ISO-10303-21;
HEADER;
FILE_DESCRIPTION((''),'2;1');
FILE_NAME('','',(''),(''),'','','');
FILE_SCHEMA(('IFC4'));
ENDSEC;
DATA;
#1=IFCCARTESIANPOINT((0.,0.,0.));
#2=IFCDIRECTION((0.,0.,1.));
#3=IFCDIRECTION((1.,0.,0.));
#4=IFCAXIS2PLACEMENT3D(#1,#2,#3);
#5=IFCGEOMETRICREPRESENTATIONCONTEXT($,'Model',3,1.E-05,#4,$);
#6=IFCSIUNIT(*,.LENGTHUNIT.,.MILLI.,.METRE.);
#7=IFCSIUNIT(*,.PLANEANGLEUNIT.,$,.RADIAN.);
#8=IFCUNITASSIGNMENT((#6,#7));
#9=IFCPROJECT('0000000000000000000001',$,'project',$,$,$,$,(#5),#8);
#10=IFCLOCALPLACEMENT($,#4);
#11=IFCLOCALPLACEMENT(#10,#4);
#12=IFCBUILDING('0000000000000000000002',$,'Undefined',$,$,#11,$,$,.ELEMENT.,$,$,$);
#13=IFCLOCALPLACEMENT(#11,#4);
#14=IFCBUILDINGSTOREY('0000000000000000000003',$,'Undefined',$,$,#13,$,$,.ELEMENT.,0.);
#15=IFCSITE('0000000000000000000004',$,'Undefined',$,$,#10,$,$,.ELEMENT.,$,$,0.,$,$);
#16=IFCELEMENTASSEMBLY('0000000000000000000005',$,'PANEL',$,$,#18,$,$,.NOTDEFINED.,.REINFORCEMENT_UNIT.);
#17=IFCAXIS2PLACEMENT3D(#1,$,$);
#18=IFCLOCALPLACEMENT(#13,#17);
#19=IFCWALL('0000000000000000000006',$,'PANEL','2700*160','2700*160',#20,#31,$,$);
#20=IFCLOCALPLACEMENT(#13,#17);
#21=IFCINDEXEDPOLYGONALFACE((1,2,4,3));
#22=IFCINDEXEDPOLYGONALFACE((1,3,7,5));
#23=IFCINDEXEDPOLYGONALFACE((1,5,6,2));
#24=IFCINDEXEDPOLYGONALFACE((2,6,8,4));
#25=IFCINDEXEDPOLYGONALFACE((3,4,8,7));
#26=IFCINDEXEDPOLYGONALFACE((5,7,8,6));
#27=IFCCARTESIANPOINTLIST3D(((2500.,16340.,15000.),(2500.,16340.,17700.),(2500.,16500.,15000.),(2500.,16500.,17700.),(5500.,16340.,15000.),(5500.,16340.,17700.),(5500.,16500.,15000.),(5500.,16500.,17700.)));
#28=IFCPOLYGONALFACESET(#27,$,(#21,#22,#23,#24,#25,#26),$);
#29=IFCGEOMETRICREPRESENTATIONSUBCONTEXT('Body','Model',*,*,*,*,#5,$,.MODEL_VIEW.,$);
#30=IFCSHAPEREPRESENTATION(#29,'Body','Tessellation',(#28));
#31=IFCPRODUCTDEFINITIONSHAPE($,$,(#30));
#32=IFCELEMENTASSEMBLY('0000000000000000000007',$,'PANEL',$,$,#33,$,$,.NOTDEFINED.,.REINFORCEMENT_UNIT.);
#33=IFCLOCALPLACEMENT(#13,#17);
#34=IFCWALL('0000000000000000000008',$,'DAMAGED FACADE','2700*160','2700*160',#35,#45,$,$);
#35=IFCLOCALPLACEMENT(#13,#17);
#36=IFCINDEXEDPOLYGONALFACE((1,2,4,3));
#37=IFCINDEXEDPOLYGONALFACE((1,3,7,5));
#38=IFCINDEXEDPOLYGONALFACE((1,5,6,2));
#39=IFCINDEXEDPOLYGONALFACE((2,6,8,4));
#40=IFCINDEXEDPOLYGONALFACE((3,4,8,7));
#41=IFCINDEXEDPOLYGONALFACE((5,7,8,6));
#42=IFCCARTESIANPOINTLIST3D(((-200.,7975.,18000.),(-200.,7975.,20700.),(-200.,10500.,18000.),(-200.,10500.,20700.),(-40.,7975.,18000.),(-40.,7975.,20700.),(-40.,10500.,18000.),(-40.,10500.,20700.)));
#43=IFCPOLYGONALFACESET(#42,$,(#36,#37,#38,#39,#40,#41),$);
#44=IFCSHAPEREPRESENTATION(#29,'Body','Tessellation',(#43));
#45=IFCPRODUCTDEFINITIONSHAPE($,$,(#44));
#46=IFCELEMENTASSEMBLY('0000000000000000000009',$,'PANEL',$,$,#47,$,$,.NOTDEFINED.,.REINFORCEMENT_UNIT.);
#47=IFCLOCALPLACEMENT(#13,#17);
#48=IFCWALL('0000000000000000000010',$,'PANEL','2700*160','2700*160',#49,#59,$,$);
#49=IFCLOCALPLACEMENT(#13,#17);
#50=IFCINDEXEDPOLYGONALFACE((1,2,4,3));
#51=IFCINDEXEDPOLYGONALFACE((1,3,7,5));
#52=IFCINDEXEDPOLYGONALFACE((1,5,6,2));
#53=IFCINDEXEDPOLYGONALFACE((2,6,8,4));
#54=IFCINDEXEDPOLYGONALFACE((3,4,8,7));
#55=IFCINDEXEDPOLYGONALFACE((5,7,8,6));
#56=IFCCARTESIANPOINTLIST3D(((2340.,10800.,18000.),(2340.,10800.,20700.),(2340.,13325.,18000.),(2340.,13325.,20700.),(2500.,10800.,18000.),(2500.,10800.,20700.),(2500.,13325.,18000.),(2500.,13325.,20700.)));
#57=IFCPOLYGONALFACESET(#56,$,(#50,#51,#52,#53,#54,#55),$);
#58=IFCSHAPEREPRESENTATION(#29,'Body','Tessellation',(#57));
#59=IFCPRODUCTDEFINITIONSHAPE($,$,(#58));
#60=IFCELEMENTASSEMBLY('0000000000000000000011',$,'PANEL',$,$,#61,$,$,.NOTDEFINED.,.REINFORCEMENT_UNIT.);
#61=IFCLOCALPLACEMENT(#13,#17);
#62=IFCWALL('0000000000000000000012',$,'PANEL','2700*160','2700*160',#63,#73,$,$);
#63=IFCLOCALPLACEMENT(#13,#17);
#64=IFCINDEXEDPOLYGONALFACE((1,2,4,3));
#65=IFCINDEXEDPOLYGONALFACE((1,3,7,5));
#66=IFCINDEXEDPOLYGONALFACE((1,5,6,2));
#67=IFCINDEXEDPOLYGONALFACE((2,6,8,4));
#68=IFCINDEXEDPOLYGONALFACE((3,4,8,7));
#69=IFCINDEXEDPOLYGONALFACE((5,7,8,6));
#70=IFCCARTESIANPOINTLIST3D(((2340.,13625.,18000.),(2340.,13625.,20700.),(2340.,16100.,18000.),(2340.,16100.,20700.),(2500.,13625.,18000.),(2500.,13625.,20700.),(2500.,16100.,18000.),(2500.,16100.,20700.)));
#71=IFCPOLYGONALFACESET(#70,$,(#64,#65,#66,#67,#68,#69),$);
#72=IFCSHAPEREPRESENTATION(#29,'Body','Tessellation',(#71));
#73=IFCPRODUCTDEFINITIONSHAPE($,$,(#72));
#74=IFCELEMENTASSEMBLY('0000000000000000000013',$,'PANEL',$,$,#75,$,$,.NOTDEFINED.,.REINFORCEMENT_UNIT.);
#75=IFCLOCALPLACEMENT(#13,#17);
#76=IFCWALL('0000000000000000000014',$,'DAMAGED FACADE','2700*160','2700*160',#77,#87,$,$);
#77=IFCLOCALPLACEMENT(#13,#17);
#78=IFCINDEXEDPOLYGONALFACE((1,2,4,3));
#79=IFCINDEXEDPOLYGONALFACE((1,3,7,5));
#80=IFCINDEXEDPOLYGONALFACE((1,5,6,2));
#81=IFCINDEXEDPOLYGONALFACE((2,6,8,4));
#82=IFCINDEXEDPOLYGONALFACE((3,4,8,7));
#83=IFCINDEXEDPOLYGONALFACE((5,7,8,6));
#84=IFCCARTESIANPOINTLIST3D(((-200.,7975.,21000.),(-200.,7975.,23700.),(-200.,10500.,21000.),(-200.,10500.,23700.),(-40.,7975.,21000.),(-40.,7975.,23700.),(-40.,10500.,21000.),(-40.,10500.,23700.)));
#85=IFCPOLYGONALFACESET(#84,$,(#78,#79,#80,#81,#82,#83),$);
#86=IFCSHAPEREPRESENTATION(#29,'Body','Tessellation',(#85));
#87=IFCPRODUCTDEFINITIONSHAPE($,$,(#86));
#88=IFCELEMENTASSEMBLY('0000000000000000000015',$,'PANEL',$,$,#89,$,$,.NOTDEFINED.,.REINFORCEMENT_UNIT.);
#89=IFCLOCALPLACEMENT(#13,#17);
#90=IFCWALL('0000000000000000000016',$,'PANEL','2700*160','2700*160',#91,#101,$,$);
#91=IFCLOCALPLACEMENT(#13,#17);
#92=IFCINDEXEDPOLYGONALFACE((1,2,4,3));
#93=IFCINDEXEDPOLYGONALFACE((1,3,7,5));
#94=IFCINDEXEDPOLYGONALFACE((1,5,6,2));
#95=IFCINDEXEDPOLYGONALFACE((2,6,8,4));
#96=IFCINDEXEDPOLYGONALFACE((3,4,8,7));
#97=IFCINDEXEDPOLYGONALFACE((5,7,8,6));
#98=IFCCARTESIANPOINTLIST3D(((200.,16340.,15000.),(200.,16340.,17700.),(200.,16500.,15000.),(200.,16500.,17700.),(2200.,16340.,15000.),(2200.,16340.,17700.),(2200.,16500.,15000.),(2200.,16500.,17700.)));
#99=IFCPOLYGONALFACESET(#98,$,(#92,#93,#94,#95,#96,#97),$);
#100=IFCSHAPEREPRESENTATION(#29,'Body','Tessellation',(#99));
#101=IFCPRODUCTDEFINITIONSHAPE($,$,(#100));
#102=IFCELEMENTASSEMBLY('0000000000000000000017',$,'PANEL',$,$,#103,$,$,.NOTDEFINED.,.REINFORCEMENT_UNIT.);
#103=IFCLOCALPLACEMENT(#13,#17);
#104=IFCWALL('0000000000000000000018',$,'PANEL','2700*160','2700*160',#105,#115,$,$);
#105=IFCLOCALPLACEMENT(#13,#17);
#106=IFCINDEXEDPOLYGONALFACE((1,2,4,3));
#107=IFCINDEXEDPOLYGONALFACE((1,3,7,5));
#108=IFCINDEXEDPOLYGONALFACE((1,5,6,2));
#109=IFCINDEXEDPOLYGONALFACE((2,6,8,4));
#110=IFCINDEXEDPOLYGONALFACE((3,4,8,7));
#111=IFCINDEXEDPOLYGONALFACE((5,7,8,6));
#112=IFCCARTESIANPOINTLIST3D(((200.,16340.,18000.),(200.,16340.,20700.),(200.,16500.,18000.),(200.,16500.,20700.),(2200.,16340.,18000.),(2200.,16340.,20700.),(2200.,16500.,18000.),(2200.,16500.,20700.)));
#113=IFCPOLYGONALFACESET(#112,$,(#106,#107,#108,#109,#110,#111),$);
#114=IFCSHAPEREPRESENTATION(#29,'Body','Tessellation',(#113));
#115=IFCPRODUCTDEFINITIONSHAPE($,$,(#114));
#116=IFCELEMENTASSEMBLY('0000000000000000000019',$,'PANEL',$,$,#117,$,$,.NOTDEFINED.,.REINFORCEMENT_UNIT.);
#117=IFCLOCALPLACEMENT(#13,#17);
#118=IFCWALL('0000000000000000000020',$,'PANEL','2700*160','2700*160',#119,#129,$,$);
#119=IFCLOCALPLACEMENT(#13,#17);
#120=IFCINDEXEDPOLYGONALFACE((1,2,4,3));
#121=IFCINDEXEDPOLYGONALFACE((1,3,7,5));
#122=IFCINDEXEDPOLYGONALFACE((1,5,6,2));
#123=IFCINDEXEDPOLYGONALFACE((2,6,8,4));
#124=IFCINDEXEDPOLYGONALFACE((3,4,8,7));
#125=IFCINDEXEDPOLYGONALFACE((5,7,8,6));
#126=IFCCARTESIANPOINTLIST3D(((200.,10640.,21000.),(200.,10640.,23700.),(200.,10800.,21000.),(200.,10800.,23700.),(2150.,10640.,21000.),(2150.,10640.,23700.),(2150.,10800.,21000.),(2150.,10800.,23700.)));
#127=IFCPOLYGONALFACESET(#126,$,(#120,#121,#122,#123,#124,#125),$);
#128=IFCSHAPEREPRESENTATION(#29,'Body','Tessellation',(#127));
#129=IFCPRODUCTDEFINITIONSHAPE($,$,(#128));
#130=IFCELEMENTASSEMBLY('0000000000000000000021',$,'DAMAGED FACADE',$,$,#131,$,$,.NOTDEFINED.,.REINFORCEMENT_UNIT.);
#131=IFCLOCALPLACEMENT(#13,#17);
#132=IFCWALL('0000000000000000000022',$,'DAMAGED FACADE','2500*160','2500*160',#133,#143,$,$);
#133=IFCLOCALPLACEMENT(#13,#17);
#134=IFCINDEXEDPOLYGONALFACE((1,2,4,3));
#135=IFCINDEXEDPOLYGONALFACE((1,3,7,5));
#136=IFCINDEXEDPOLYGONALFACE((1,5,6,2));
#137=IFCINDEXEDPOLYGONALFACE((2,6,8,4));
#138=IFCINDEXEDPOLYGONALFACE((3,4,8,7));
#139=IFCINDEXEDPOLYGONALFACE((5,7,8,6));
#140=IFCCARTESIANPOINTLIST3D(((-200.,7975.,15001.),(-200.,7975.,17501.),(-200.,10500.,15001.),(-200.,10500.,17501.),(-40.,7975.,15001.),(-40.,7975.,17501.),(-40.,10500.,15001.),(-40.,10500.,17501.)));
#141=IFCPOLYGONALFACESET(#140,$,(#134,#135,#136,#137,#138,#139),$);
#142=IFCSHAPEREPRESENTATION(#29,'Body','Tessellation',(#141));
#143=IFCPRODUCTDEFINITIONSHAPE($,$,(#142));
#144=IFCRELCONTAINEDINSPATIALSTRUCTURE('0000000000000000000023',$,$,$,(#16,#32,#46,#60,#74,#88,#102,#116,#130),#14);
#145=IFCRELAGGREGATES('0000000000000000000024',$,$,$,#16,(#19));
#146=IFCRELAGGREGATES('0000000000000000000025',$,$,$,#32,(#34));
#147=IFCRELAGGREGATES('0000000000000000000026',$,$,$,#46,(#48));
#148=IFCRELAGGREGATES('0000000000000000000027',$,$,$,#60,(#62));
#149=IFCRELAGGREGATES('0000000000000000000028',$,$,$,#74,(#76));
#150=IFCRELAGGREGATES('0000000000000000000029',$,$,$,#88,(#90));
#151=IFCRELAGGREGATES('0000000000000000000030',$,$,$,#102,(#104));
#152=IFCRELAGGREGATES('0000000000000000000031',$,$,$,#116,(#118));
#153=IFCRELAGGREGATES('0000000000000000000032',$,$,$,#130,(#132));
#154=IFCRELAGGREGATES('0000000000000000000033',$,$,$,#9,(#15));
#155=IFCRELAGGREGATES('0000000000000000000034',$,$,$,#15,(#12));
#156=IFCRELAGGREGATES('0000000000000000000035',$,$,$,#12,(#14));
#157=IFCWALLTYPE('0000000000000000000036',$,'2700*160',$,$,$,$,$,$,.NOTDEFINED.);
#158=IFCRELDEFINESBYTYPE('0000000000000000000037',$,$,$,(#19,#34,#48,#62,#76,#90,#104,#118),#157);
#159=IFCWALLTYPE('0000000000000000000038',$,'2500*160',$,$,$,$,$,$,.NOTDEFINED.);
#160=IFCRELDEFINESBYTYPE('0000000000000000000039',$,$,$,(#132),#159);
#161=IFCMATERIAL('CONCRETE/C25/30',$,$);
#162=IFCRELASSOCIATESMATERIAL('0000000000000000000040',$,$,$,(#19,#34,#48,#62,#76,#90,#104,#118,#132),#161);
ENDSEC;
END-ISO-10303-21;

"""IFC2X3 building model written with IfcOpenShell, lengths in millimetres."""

from ifc_helpers import new_model, si_unit, frame, frame_2d, origin_with_axes, place, context, subcontext, project, spatial, rectangle, extrude, material, type_object, element, aggregate, save


model = new_model("IFC2X3")

# Units and contexts
model_context = context("Model", 3, precision=1e-05, world=origin_with_axes())
body_context = subcontext(model_context, "Body", "Model", "MODEL_VIEW")
ifc_project = project(units=[si_unit("LENGTHUNIT", "METRE", prefix="MILLI"), si_unit("PLANEANGLEUNIT", "RADIAN")], contexts=[model_context])

# Site, building, storey
site_placement = place(None, origin_with_axes())
site = spatial("IfcSite", under=ifc_project, at=site_placement, Name="Undefined", CompositionType="ELEMENT", RefElevation=0.0)
building_placement = place(site_placement, origin_with_axes())
building = spatial("IfcBuilding", under=site, at=building_placement, Name="Undefined", CompositionType="ELEMENT")
storey_placement = place(building_placement, origin_with_axes())
storey = spatial("IfcBuildingStorey", under=building, at=storey_placement, Name="Undefined", CompositionType="ELEMENT", Elevation=0.0)

# Shared definitions
ifc_material = material(Name="CONCRETE/C25/30")

# Element assemblies, walls
assembly_1_placement = place(storey_placement, origin_with_axes())
assembly_1 = element("IfcElementAssembly", 1, at=assembly_1_placement, inside=storey, Name="PANEL", AssemblyPlace="NOTDEFINED", PredefinedType="REINFORCEMENT_UNIT")
wall_type_1 = type_object("IfcWallType", Name="2700*160", PredefinedType="NOTDEFINED")
wall_1_placement = place(assembly_1_placement, frame((2500.0, 16420.0, 15000.0), z_axis=(0.0, 0.0, 1.0), x_axis=(1.0, 0.0, 0.0)))
wall_1 = element("IfcWall", 2, at=wall_1_placement, type_object=wall_type_1, material=ifc_material, Name="PANEL", Description="2700*160", ObjectType="2700*160", context=body_context, shape_type="SweptSolid", body=[
    extrude(rectangle(XDim=3000.0, YDim=160.0, at=frame_2d((0.0, 1500.0), x_axis=(0.0, -1.0))), frame((0.0, 0.0, 0.0), z_axis=(0.0, 0.0, 1.0), x_axis=(0.0, -1.0, 0.0)), (0.0, 0.0, 1.0), 2700.0),
])
aggregate(assembly_1, [wall_1])
assembly_2_placement = place(storey_placement, origin_with_axes())
assembly_2 = element("IfcElementAssembly", 3, at=assembly_2_placement, inside=storey, Name="PANEL", AssemblyPlace="NOTDEFINED", PredefinedType="REINFORCEMENT_UNIT")
wall_2_placement = place(assembly_2_placement, frame((-120.0, 10500.0, 18000.0), z_axis=(0.0, 0.0, 1.0), x_axis=(0.0, -1.0, 0.0)))
wall_2 = element("IfcWall", 4, at=wall_2_placement, type_object=wall_type_1, material=ifc_material, Name="DAMAGED FACADE", Description="2700*160", ObjectType="2700*160", context=body_context, shape_type="SweptSolid", body=[
    extrude(rectangle(XDim=2525.0, YDim=160.0, at=frame_2d((0.0, 1262.5), x_axis=(0.0, -1.0))), frame((0.0, 0.0, 0.0), z_axis=(0.0, 0.0, 1.0), x_axis=(0.0, -1.0, 0.0)), (0.0, 0.0, 1.0), 2700.0),
])
aggregate(assembly_2, [wall_2])
assembly_3_placement = place(storey_placement, origin_with_axes())
assembly_3 = element("IfcElementAssembly", 5, at=assembly_3_placement, inside=storey, Name="PANEL", AssemblyPlace="NOTDEFINED", PredefinedType="REINFORCEMENT_UNIT")
wall_3_placement = place(assembly_3_placement, frame((2420.0, 10800.0, 18000.0), z_axis=(0.0, 0.0, 1.0), x_axis=(0.0, 1.0, 0.0)))
wall_3 = element("IfcWall", 6, at=wall_3_placement, type_object=wall_type_1, material=ifc_material, Name="PANEL", Description="2700*160", ObjectType="2700*160", context=body_context, shape_type="SweptSolid", body=[
    extrude(rectangle(XDim=2525.0, YDim=160.0, at=frame_2d((0.0, 1262.5), x_axis=(0.0, -1.0))), frame((0.0, 0.0, 0.0), z_axis=(0.0, 0.0, 1.0), x_axis=(0.0, -1.0, 0.0)), (0.0, 0.0, 1.0), 2700.0),
])
aggregate(assembly_3, [wall_3])
assembly_4_placement = place(storey_placement, origin_with_axes())
assembly_4 = element("IfcElementAssembly", 7, at=assembly_4_placement, inside=storey, Name="PANEL", AssemblyPlace="NOTDEFINED", PredefinedType="REINFORCEMENT_UNIT")
wall_4_placement = place(assembly_4_placement, frame((2420.0, 13625.0, 18000.0), z_axis=(0.0, 0.0, 1.0), x_axis=(0.0, 1.0, 0.0)))
wall_4 = element("IfcWall", 8, at=wall_4_placement, type_object=wall_type_1, material=ifc_material, Name="PANEL", Description="2700*160", ObjectType="2700*160", context=body_context, shape_type="SweptSolid", body=[
    extrude(rectangle(XDim=2475.0, YDim=160.0, at=frame_2d((0.0, 1237.5), x_axis=(0.0, -1.0))), frame((0.0, 0.0, 0.0), z_axis=(0.0, 0.0, 1.0), x_axis=(0.0, -1.0, 0.0)), (0.0, 0.0, 1.0), 2700.0),
])
aggregate(assembly_4, [wall_4])
assembly_5_placement = place(storey_placement, origin_with_axes())
assembly_5 = element("IfcElementAssembly", 9, at=assembly_5_placement, inside=storey, Name="PANEL", AssemblyPlace="NOTDEFINED", PredefinedType="REINFORCEMENT_UNIT")
wall_5_placement = place(assembly_5_placement, frame((-120.0, 10500.0, 21000.0), z_axis=(0.0, 0.0, 1.0), x_axis=(0.0, -1.0, 0.0)))
wall_5 = element("IfcWall", 10, at=wall_5_placement, type_object=wall_type_1, material=ifc_material, Name="DAMAGED FACADE", Description="2700*160", ObjectType="2700*160", context=body_context, shape_type="SweptSolid", body=[
    extrude(rectangle(XDim=2525.0, YDim=160.0, at=frame_2d((0.0, 1262.5), x_axis=(0.0, -1.0))), frame((0.0, 0.0, 0.0), z_axis=(0.0, 0.0, 1.0), x_axis=(0.0, -1.0, 0.0)), (0.0, 0.0, 1.0), 2700.0),
])
aggregate(assembly_5, [wall_5])
assembly_6_placement = place(storey_placement, origin_with_axes())
assembly_6 = element("IfcElementAssembly", 11, at=assembly_6_placement, inside=storey, Name="PANEL", AssemblyPlace="NOTDEFINED", PredefinedType="REINFORCEMENT_UNIT")
wall_6_placement = place(assembly_6_placement, frame((2200.0, 16420.0, 15000.0), z_axis=(0.0, 0.0, 1.0), x_axis=(-1.0, 0.0, 0.0)))
wall_6 = element("IfcWall", 12, at=wall_6_placement, type_object=wall_type_1, material=ifc_material, Name="PANEL", Description="2700*160", ObjectType="2700*160", context=body_context, shape_type="SweptSolid", body=[
    extrude(rectangle(XDim=2000.0, YDim=160.0, at=frame_2d((0.0, 1000.0), x_axis=(0.0, -1.0))), frame((0.0, 0.0, 0.0), z_axis=(0.0, 0.0, 1.0), x_axis=(0.0, -1.0, 0.0)), (0.0, 0.0, 1.0), 2700.0),
])
aggregate(assembly_6, [wall_6])
assembly_7_placement = place(storey_placement, origin_with_axes())
assembly_7 = element("IfcElementAssembly", 13, at=assembly_7_placement, inside=storey, Name="PANEL", AssemblyPlace="NOTDEFINED", PredefinedType="REINFORCEMENT_UNIT")
wall_7_placement = place(assembly_7_placement, frame((2200.0, 16420.0, 18000.0), z_axis=(0.0, 0.0, 1.0), x_axis=(-1.0, 0.0, 0.0)))
wall_7 = element("IfcWall", 14, at=wall_7_placement, type_object=wall_type_1, material=ifc_material, Name="PANEL", Description="2700*160", ObjectType="2700*160", context=body_context, shape_type="SweptSolid", body=[
    extrude(rectangle(XDim=2000.0, YDim=160.0, at=frame_2d((0.0, 1000.0), x_axis=(0.0, -1.0))), frame((0.0, 0.0, 0.0), z_axis=(0.0, 0.0, 1.0), x_axis=(0.0, -1.0, 0.0)), (0.0, 0.0, 1.0), 2700.0),
])
aggregate(assembly_7, [wall_7])
assembly_8_placement = place(storey_placement, origin_with_axes())
assembly_8 = element("IfcElementAssembly", 15, at=assembly_8_placement, inside=storey, Name="PANEL", AssemblyPlace="NOTDEFINED", PredefinedType="REINFORCEMENT_UNIT")
wall_8_placement = place(assembly_8_placement, frame((2150.0, 10720.0, 21000.0), z_axis=(0.0, 0.0, 1.0), x_axis=(-1.0, 0.0, 0.0)))
wall_8 = element("IfcWall", 16, at=wall_8_placement, type_object=wall_type_1, material=ifc_material, Name="PANEL", Description="2700*160", ObjectType="2700*160", context=body_context, shape_type="SweptSolid", body=[
    extrude(rectangle(XDim=1950.0, YDim=160.0, at=frame_2d((0.0, 975.0), x_axis=(0.0, -1.0))), frame((0.0, 0.0, 0.0), z_axis=(0.0, 0.0, 1.0), x_axis=(0.0, -1.0, 0.0)), (0.0, 0.0, 1.0), 2700.0),
])
aggregate(assembly_8, [wall_8])
assembly_9_placement = place(storey_placement, origin_with_axes())
assembly_9 = element("IfcElementAssembly", 17, at=assembly_9_placement, inside=storey, Name="DAMAGED FACADE", AssemblyPlace="NOTDEFINED", PredefinedType="REINFORCEMENT_UNIT")
wall_type_2 = type_object("IfcWallType", Name="2500*160", PredefinedType="NOTDEFINED")
wall_9_placement = place(assembly_9_placement, frame((-120.0, 10500.0, 15001.0), z_axis=(0.0, 0.0, 1.0), x_axis=(0.0, -1.0, 0.0)))
wall_9 = element("IfcWall", 18, at=wall_9_placement, type_object=wall_type_2, material=ifc_material, Name="DAMAGED FACADE", Description="2500*160", ObjectType="2500*160", context=body_context, shape_type="SweptSolid", body=[
    extrude(rectangle(XDim=2525.0, YDim=160.0, at=frame_2d((0.0, 1262.5), x_axis=(0.0, -1.0))), frame((0.0, 0.0, 0.0), z_axis=(0.0, 0.0, 1.0), x_axis=(0.0, -1.0, 0.0)), (0.0, 0.0, 1.0), 2500.0),
])
aggregate(assembly_9, [wall_9])

save(model, "model.ifc")
